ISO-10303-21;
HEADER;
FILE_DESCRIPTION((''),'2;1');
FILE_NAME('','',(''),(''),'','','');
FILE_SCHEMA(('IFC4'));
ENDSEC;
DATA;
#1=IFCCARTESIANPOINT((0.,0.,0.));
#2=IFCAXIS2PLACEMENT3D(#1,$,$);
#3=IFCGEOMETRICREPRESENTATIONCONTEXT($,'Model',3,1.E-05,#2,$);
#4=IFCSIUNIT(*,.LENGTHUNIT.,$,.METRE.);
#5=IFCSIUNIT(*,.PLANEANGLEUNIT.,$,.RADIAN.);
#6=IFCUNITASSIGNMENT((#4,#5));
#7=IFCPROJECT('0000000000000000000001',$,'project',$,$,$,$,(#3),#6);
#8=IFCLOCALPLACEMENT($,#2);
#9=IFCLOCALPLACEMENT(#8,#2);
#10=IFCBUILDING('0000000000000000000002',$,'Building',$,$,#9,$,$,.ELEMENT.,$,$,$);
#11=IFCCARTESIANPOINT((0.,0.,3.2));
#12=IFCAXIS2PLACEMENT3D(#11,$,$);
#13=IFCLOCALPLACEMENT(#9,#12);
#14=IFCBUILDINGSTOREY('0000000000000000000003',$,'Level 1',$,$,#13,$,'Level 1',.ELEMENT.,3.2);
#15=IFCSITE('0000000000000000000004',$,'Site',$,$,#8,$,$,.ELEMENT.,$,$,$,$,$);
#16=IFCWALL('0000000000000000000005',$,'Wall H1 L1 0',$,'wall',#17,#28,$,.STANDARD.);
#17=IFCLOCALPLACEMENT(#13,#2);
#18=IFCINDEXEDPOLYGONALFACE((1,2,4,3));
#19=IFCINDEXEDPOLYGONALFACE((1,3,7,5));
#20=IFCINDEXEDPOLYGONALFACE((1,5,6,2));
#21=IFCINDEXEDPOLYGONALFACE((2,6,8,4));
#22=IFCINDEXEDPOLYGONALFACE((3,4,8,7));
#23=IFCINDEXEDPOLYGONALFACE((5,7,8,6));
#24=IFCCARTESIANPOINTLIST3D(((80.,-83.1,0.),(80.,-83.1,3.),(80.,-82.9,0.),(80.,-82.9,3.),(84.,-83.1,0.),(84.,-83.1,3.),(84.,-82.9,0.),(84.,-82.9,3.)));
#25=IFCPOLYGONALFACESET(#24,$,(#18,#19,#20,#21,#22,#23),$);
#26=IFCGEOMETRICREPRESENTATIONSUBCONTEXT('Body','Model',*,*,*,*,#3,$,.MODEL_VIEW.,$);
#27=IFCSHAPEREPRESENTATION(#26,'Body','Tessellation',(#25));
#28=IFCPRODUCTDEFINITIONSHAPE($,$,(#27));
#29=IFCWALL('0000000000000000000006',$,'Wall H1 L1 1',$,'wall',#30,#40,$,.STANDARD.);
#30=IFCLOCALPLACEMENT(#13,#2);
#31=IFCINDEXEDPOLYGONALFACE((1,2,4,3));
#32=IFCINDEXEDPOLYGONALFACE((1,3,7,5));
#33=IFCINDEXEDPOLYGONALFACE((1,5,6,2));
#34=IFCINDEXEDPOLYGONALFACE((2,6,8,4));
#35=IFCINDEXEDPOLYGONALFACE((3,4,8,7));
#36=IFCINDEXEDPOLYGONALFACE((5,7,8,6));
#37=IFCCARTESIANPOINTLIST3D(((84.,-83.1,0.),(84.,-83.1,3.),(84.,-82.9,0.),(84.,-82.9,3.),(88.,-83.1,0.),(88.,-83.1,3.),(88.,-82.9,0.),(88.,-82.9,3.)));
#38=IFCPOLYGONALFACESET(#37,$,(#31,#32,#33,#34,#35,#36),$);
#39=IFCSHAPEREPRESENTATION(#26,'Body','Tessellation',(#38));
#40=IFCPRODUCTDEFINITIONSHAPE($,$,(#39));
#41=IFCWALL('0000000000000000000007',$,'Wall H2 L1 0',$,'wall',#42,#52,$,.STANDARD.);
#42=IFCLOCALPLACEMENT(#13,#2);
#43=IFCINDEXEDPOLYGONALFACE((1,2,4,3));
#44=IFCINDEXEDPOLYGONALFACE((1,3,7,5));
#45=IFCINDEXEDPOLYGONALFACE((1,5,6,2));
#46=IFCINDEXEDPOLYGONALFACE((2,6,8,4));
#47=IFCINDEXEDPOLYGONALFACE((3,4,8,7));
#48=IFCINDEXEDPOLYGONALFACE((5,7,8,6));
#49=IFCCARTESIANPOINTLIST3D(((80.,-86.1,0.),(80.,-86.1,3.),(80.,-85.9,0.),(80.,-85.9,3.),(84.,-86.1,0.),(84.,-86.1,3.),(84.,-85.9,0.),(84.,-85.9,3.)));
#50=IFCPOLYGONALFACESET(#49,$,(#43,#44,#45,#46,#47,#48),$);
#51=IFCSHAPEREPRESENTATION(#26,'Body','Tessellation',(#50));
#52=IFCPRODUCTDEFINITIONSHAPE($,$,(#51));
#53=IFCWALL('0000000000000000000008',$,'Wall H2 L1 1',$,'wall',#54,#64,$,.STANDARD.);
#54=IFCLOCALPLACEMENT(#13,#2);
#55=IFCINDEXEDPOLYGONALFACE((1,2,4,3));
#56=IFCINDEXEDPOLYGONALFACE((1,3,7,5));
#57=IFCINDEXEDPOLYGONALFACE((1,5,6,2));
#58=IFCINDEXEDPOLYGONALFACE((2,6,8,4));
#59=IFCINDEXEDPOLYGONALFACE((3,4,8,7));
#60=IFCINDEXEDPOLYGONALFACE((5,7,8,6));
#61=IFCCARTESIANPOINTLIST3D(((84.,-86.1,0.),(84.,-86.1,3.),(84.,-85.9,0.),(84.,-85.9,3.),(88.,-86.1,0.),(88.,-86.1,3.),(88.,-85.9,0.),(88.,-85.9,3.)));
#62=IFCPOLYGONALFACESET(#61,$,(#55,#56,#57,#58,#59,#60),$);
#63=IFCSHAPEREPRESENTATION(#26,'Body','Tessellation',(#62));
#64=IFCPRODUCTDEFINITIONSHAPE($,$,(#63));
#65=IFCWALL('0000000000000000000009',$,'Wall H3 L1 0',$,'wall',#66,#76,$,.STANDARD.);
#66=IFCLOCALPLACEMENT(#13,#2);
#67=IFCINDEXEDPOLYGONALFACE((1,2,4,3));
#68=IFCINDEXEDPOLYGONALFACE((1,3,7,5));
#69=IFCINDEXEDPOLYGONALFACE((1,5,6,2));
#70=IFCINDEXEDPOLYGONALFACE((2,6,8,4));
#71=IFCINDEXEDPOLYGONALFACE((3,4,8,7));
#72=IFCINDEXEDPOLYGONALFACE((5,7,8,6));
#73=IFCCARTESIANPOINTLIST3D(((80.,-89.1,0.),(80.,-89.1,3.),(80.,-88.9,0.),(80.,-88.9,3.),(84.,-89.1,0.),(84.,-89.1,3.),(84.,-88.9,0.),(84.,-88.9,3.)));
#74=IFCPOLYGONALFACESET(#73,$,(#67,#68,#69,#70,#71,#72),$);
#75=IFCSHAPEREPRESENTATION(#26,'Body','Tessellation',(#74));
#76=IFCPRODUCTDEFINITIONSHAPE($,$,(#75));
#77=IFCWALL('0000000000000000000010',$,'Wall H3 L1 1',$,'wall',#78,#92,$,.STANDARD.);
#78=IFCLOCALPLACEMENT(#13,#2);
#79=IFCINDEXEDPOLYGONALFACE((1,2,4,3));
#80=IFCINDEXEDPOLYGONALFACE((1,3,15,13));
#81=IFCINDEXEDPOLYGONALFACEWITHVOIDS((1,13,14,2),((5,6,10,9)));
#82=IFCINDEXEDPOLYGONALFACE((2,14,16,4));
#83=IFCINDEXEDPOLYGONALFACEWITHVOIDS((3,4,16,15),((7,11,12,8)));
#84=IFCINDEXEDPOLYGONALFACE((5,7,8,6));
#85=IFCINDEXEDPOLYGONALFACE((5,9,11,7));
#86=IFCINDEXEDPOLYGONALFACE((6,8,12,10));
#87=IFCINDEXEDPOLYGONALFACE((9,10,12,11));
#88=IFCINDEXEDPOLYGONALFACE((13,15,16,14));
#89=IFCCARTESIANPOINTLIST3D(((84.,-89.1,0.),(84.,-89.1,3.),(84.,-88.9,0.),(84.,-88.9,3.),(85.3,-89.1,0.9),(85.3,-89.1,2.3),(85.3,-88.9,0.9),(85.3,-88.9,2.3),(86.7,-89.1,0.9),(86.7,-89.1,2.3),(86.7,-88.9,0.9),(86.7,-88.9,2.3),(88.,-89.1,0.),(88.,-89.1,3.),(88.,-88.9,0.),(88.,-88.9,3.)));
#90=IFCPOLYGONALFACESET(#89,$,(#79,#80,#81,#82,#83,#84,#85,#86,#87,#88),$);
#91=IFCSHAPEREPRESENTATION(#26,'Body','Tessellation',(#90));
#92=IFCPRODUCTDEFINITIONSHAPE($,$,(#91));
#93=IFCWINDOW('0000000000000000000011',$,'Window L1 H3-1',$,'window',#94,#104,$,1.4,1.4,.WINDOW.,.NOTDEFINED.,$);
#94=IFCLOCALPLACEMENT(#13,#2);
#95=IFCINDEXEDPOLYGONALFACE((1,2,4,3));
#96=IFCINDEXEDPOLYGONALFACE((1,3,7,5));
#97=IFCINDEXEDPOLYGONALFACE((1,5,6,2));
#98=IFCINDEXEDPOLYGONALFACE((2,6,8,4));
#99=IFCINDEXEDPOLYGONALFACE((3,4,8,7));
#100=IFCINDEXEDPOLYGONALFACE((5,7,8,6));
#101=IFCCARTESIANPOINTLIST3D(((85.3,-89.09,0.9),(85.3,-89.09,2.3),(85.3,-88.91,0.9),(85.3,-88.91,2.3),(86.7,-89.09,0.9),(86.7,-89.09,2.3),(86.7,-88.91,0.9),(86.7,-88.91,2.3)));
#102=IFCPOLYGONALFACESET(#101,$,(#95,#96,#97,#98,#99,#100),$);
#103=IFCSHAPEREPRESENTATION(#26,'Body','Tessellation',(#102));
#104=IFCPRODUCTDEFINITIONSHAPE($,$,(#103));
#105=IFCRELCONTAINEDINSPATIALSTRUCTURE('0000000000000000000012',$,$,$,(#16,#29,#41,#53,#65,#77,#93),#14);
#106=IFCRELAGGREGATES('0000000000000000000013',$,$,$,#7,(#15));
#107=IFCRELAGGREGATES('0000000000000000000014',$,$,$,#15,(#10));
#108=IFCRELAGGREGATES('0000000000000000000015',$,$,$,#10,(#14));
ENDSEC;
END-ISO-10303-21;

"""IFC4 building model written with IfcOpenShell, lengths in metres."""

from ifc_helpers import new_model, si_unit, frame, frame_2d, origin, origin_2d, place, context, subcontext, project, spatial, rectangle, extrude, element, fill, save


model = new_model("IFC4")

# Units and contexts
model_context = context("Model", 3, precision=1e-05, world=origin())
body_context = subcontext(model_context, "Body", "Model", "MODEL_VIEW")
ifc_project = project(units=[si_unit("LENGTHUNIT", "METRE"), si_unit("PLANEANGLEUNIT", "RADIAN")], contexts=[model_context])

# Site, building, storey
site_placement = place(None, origin())
site = spatial("IfcSite", under=ifc_project, at=site_placement, Name="Site", CompositionType="ELEMENT")
building_placement = place(site_placement, origin())
building = spatial("IfcBuilding", under=site, at=building_placement, Name="Building", CompositionType="ELEMENT")
storey_placement = place(building_placement, frame((0.0, 0.0, 3.2)))
storey = spatial("IfcBuildingStorey", under=building, at=storey_placement, Name="Level 1", LongName="Level 1", CompositionType="ELEMENT", Elevation=3.2)

# Walls
for number, where, z_axis, x_axis, name in (
    (1, (80.0, -83.0, 0.0), (0.0, 0.0, 1.0), (1.0, 0.0, 0.0), "Wall H1 L1 0"),
    (2, (84.0, -83.0, 0.0), (0.0, 0.0, 1.0), (1.0, 0.0, 0.0), "Wall H1 L1 1"),
    (3, (80.0, -86.0, 0.0), (0.0, 0.0, 1.0), (1.0, 0.0, 0.0), "Wall H2 L1 0"),
    (4, (84.0, -86.0, 0.0), (0.0, 0.0, 1.0), (1.0, 0.0, 0.0), "Wall H2 L1 1"),
    (5, (80.0, -89.0, 0.0), (0.0, 0.0, 1.0), (1.0, 0.0, 0.0), "Wall H3 L1 0"),
):
    element("IfcWall", number, at=place(storey_placement, frame(where, z_axis=z_axis, x_axis=x_axis)), inside=storey, Name=name, ObjectType="wall", PredefinedType="STANDARD", context=body_context, shape_type="SweptSolid", body=[
        extrude(rectangle(XDim=4.0, YDim=0.2, at=frame_2d((2.0, 0.0))), origin(), (0.0, 0.0, 1.0), 3.0),
    ])

# Wall, opening, window
wall_1_placement = place(storey_placement, frame((84.0, -89.0, 0.0), z_axis=(0.0, 0.0, 1.0), x_axis=(1.0, 0.0, 0.0)))
wall_1 = element("IfcWall", 6, at=wall_1_placement, inside=storey, Name="Wall H3 L1 1", ObjectType="wall", PredefinedType="STANDARD", context=body_context, shape_type="SweptSolid", body=[
    extrude(rectangle(XDim=4.0, YDim=0.2, at=frame_2d((2.0, 0.0))), origin(), (0.0, 0.0, 1.0), 3.0),
])
opening_1_placement = place(storey_placement, frame((86.0, -89.0, 0.9), z_axis=(0.0, 0.0, 1.0), x_axis=(1.0, 0.0, 0.0)))
opening_1 = element("IfcOpeningElement", 7, at=opening_1_placement, cuts=wall_1, ObjectType="Opening", PredefinedType="OPENING", context=body_context, shape_type="SweptSolid", body=[
    extrude(rectangle(XDim=1.4, YDim=0.22, at=origin_2d()), origin(), (0.0, 0.0, 1.0), 1.4),
])
window_1_placement = place(storey_placement, frame((86.0, -89.0, 0.9), z_axis=(0.0, 0.0, 1.0), x_axis=(1.0, 0.0, 0.0)))
window_1 = element("IfcWindow", 8, at=window_1_placement, inside=storey, Name="Window L1 H3-1", ObjectType="window", OverallHeight=1.4, OverallWidth=1.4, PartitioningType="NOTDEFINED", PredefinedType="WINDOW", context=body_context, shape_type="SweptSolid", body=[
    extrude(rectangle(XDim=1.4, YDim=0.18, at=origin_2d()), origin(), (0.0, 0.0, 1.0), 1.4),
])
fill(opening_1, window_1)

save(model, "model.ifc")
